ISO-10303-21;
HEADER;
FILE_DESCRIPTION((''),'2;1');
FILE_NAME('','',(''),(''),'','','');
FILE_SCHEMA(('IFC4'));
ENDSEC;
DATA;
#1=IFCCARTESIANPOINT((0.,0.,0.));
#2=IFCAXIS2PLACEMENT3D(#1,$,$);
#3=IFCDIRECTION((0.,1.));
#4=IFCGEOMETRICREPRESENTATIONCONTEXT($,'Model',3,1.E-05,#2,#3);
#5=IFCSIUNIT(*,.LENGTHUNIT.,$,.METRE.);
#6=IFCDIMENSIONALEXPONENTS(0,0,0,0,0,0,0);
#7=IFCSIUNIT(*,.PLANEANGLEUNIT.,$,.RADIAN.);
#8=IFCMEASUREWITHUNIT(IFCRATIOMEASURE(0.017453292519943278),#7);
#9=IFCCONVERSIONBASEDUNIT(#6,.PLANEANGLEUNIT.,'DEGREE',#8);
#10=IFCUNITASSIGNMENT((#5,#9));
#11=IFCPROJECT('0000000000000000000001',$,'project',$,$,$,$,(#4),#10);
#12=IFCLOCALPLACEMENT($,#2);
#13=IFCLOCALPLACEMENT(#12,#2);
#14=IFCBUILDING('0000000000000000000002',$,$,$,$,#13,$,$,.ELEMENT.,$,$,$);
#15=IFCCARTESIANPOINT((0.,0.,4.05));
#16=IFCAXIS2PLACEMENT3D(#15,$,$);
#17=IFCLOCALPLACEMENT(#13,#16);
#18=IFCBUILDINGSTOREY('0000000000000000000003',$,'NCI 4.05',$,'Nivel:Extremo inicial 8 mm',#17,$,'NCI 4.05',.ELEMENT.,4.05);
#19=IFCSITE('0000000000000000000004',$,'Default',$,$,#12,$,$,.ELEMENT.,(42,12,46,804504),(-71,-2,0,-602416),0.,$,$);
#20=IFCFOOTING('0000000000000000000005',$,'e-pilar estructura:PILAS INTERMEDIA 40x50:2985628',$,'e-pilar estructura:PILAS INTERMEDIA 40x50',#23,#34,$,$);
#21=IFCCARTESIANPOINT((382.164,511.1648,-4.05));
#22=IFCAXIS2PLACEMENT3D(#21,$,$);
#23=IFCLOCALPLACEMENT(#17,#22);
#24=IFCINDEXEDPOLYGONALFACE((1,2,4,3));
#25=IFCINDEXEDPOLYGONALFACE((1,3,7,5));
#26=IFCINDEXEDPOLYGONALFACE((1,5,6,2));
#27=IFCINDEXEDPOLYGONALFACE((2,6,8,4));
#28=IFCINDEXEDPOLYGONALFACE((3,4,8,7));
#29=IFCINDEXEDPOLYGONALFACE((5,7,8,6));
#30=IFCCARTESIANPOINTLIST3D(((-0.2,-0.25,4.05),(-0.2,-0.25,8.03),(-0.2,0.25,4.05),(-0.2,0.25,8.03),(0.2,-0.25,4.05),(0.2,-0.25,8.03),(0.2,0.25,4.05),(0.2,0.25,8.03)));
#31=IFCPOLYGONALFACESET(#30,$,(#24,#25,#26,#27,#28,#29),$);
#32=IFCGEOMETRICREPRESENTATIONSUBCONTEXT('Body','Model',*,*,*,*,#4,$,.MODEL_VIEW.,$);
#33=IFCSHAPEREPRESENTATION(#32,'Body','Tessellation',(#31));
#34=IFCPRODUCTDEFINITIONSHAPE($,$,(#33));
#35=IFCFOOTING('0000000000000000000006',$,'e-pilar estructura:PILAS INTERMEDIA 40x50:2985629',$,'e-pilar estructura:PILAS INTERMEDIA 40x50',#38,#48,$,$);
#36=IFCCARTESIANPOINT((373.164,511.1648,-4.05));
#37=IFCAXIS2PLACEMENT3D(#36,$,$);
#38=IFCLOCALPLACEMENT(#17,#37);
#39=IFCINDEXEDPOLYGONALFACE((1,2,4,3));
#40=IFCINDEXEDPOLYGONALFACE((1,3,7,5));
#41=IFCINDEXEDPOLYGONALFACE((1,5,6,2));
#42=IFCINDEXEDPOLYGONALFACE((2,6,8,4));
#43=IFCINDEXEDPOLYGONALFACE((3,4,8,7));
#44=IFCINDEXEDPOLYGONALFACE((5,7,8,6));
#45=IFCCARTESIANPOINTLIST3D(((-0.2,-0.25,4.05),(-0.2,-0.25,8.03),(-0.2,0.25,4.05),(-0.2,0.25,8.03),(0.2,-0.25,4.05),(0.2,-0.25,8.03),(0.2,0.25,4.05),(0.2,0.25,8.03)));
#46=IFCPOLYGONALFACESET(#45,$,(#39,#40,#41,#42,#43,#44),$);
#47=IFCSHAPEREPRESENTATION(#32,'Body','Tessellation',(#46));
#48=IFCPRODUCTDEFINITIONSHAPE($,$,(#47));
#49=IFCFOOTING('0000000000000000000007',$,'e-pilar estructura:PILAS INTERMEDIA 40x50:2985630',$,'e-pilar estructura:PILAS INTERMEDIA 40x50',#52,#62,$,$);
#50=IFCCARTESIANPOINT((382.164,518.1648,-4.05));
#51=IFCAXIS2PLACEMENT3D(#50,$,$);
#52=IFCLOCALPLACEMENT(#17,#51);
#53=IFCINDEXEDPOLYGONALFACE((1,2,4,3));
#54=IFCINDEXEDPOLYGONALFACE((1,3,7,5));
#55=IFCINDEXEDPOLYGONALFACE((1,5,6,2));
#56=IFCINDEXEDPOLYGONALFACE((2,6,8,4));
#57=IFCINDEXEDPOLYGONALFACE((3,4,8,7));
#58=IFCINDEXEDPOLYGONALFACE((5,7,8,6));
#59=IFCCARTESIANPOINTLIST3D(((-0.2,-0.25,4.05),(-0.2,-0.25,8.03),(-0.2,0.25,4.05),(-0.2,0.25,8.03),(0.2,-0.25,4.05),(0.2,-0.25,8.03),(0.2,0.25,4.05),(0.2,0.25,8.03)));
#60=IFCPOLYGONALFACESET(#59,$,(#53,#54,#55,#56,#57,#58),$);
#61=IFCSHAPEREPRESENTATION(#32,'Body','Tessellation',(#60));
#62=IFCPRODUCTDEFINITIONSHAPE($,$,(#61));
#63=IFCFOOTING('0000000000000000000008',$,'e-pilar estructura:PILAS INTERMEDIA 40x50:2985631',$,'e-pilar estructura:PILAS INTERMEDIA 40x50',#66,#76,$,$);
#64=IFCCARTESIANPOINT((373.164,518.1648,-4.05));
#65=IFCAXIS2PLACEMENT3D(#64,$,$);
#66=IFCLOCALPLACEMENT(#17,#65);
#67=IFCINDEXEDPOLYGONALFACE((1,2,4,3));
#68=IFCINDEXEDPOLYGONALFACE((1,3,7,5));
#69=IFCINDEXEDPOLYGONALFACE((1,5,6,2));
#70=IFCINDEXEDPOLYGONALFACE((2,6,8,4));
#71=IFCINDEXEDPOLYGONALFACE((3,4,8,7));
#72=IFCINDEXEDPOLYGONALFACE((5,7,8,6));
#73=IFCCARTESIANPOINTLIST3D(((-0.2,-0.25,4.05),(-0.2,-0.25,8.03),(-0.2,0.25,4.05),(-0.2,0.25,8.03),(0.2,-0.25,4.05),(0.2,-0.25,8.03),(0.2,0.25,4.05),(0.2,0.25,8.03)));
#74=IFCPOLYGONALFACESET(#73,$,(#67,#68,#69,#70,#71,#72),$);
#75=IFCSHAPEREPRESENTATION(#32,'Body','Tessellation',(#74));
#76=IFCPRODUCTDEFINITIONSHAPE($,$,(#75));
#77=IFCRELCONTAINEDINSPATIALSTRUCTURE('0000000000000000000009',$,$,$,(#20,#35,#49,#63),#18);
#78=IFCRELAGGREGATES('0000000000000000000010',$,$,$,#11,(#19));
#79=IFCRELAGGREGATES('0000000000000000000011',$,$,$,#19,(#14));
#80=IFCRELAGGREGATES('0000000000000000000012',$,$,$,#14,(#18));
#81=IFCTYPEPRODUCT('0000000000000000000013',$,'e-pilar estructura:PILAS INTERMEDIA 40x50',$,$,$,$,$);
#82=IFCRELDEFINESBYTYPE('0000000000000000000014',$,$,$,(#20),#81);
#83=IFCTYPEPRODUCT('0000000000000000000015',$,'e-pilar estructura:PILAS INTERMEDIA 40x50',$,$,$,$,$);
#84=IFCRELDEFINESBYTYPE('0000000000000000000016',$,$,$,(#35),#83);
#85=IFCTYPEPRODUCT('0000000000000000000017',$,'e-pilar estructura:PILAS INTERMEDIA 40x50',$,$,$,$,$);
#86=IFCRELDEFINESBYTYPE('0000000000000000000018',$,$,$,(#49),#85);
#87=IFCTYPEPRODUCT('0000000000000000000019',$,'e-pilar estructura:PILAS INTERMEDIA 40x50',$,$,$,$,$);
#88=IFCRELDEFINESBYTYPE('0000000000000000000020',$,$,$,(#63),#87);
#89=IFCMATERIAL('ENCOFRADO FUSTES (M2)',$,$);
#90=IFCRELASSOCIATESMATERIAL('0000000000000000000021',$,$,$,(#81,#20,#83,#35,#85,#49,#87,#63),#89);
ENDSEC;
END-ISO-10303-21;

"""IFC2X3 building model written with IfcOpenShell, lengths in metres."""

from ifc_helpers import new_model, entity, si_unit, converted_unit, direction, frame, origin, origin_2d_with_axis, place, context, subcontext, project, spatial, rectangle, extrude, source, transform, mapped, material, type_object, type_shapes, element, save


model = new_model("IFC2X3")

# Units and contexts
model_context = context("Model", 3, precision=1e-05, world=origin(), true_north=direction((0.0, 1.0)))
body_context = subcontext(model_context, "Body", "Model", "MODEL_VIEW")
ifc_project = project(units=[si_unit("LENGTHUNIT", "METRE"), converted_unit("PLANEANGLEUNIT", "DEGREE", entity("IfcRatioMeasure", 0.017453292519943278), si_unit("PLANEANGLEUNIT", "RADIAN"), dimensions=[0, 0, 0, 0, 0, 0, 0])], contexts=[model_context])

# Site, building, storey
site_placement = place(None, origin())
site = spatial("IfcSite", under=ifc_project, at=site_placement, Name="Default", CompositionType="ELEMENT", RefLatitude=(42, 12, 46, 804504), RefLongitude=(-71, -2, 0, -602416), RefElevation=0.0)
building_placement = place(site_placement, origin())
building = spatial("IfcBuilding", under=site, at=building_placement, CompositionType="ELEMENT")
storey_placement = place(building_placement, frame((0.0, 0.0, 4.05)))
storey = spatial("IfcBuildingStorey", under=building, at=storey_placement, Name="NCI 4.05", ObjectType="Nivel:Extremo inicial 8 mm", LongName="NCI 4.05", CompositionType="ELEMENT", Elevation=4.05)

# Footings
ifc_material_1 = material(Name="ENCOFRADO FUSTES (M2)")
type_product_1 = type_object("IfcTypeProduct", Name="e-pilar estructura:PILAS INTERMEDIA 40x50", material=ifc_material_1)
shared_shape_1 = source(origin(), body_context, "Body", "SweptSolid", [
    extrude(rectangle(XDim=0.5, YDim=0.4, at=origin_2d_with_axis()), frame((0.0, 0.0, 4.05), z_axis=(0.0, 0.0, 1.0), x_axis=(0.0, 1.0, 0.0)), (0.0, 0.0, 1.0), 3.98),
])
type_shapes(type_product_1, [shared_shape_1])
footing_1_placement = place(storey_placement, frame((382.164, 511.1648, -4.05)))
element("IfcFooting", 1, at=footing_1_placement, inside=storey, type_object=type_product_1, material=ifc_material_1, Name="e-pilar estructura:PILAS INTERMEDIA 40x50:2985628", ObjectType="e-pilar estructura:PILAS INTERMEDIA 40x50", context=body_context, shape_type="MappedRepresentation", body=[
    mapped(shared_shape_1, transform((0.0, 0.0, 0.0), scale=1.0)),
])
type_product_2 = type_object("IfcTypeProduct", Name="e-pilar estructura:PILAS INTERMEDIA 40x50", material=ifc_material_1)
shared_shape_2 = source(origin(), body_context, "Body", "SweptSolid", [
    extrude(rectangle(XDim=0.5, YDim=0.4, at=origin_2d_with_axis()), frame((0.0, 0.0, 4.05), z_axis=(0.0, 0.0, 1.0), x_axis=(0.0, 1.0, 0.0)), (0.0, 0.0, 1.0), 3.98),
])
type_shapes(type_product_2, [shared_shape_2])
footing_2_placement = place(storey_placement, frame((373.164, 511.1648, -4.05)))
element("IfcFooting", 2, at=footing_2_placement, inside=storey, type_object=type_product_2, material=ifc_material_1, Name="e-pilar estructura:PILAS INTERMEDIA 40x50:2985629", ObjectType="e-pilar estructura:PILAS INTERMEDIA 40x50", context=body_context, shape_type="MappedRepresentation", body=[
    mapped(shared_shape_2, transform((0.0, 0.0, 0.0), scale=1.0)),
])
type_product_3 = type_object("IfcTypeProduct", Name="e-pilar estructura:PILAS INTERMEDIA 40x50", material=ifc_material_1)
shared_shape_3 = source(origin(), body_context, "Body", "SweptSolid", [
    extrude(rectangle(XDim=0.5, YDim=0.4, at=origin_2d_with_axis()), frame((0.0, 0.0, 4.05), z_axis=(0.0, 0.0, 1.0), x_axis=(0.0, 1.0, 0.0)), (0.0, 0.0, 1.0), 3.98),
])
type_shapes(type_product_3, [shared_shape_3])
footing_3_placement = place(storey_placement, frame((382.164, 518.1648, -4.05)))
element("IfcFooting", 3, at=footing_3_placement, inside=storey, type_object=type_product_3, material=ifc_material_1, Name="e-pilar estructura:PILAS INTERMEDIA 40x50:2985630", ObjectType="e-pilar estructura:PILAS INTERMEDIA 40x50", context=body_context, shape_type="MappedRepresentation", body=[
    mapped(shared_shape_3, transform((0.0, 0.0, 0.0), scale=1.0)),
])
type_product_4 = type_object("IfcTypeProduct", Name="e-pilar estructura:PILAS INTERMEDIA 40x50", material=ifc_material_1)
shared_shape_4 = source(origin(), body_context, "Body", "SweptSolid", [
    extrude(rectangle(XDim=0.5, YDim=0.4, at=origin_2d_with_axis()), frame((0.0, 0.0, 4.05), z_axis=(0.0, 0.0, 1.0), x_axis=(0.0, 1.0, 0.0)), (0.0, 0.0, 1.0), 3.98),
])
type_shapes(type_product_4, [shared_shape_4])
footing_4_placement = place(storey_placement, frame((373.164, 518.1648, -4.05)))
element("IfcFooting", 4, at=footing_4_placement, inside=storey, type_object=type_product_4, material=ifc_material_1, Name="e-pilar estructura:PILAS INTERMEDIA 40x50:2985631", ObjectType="e-pilar estructura:PILAS INTERMEDIA 40x50", context=body_context, shape_type="MappedRepresentation", body=[
    mapped(shared_shape_4, transform((0.0, 0.0, 0.0), scale=1.0)),
])

save(model, "model.ifc")
